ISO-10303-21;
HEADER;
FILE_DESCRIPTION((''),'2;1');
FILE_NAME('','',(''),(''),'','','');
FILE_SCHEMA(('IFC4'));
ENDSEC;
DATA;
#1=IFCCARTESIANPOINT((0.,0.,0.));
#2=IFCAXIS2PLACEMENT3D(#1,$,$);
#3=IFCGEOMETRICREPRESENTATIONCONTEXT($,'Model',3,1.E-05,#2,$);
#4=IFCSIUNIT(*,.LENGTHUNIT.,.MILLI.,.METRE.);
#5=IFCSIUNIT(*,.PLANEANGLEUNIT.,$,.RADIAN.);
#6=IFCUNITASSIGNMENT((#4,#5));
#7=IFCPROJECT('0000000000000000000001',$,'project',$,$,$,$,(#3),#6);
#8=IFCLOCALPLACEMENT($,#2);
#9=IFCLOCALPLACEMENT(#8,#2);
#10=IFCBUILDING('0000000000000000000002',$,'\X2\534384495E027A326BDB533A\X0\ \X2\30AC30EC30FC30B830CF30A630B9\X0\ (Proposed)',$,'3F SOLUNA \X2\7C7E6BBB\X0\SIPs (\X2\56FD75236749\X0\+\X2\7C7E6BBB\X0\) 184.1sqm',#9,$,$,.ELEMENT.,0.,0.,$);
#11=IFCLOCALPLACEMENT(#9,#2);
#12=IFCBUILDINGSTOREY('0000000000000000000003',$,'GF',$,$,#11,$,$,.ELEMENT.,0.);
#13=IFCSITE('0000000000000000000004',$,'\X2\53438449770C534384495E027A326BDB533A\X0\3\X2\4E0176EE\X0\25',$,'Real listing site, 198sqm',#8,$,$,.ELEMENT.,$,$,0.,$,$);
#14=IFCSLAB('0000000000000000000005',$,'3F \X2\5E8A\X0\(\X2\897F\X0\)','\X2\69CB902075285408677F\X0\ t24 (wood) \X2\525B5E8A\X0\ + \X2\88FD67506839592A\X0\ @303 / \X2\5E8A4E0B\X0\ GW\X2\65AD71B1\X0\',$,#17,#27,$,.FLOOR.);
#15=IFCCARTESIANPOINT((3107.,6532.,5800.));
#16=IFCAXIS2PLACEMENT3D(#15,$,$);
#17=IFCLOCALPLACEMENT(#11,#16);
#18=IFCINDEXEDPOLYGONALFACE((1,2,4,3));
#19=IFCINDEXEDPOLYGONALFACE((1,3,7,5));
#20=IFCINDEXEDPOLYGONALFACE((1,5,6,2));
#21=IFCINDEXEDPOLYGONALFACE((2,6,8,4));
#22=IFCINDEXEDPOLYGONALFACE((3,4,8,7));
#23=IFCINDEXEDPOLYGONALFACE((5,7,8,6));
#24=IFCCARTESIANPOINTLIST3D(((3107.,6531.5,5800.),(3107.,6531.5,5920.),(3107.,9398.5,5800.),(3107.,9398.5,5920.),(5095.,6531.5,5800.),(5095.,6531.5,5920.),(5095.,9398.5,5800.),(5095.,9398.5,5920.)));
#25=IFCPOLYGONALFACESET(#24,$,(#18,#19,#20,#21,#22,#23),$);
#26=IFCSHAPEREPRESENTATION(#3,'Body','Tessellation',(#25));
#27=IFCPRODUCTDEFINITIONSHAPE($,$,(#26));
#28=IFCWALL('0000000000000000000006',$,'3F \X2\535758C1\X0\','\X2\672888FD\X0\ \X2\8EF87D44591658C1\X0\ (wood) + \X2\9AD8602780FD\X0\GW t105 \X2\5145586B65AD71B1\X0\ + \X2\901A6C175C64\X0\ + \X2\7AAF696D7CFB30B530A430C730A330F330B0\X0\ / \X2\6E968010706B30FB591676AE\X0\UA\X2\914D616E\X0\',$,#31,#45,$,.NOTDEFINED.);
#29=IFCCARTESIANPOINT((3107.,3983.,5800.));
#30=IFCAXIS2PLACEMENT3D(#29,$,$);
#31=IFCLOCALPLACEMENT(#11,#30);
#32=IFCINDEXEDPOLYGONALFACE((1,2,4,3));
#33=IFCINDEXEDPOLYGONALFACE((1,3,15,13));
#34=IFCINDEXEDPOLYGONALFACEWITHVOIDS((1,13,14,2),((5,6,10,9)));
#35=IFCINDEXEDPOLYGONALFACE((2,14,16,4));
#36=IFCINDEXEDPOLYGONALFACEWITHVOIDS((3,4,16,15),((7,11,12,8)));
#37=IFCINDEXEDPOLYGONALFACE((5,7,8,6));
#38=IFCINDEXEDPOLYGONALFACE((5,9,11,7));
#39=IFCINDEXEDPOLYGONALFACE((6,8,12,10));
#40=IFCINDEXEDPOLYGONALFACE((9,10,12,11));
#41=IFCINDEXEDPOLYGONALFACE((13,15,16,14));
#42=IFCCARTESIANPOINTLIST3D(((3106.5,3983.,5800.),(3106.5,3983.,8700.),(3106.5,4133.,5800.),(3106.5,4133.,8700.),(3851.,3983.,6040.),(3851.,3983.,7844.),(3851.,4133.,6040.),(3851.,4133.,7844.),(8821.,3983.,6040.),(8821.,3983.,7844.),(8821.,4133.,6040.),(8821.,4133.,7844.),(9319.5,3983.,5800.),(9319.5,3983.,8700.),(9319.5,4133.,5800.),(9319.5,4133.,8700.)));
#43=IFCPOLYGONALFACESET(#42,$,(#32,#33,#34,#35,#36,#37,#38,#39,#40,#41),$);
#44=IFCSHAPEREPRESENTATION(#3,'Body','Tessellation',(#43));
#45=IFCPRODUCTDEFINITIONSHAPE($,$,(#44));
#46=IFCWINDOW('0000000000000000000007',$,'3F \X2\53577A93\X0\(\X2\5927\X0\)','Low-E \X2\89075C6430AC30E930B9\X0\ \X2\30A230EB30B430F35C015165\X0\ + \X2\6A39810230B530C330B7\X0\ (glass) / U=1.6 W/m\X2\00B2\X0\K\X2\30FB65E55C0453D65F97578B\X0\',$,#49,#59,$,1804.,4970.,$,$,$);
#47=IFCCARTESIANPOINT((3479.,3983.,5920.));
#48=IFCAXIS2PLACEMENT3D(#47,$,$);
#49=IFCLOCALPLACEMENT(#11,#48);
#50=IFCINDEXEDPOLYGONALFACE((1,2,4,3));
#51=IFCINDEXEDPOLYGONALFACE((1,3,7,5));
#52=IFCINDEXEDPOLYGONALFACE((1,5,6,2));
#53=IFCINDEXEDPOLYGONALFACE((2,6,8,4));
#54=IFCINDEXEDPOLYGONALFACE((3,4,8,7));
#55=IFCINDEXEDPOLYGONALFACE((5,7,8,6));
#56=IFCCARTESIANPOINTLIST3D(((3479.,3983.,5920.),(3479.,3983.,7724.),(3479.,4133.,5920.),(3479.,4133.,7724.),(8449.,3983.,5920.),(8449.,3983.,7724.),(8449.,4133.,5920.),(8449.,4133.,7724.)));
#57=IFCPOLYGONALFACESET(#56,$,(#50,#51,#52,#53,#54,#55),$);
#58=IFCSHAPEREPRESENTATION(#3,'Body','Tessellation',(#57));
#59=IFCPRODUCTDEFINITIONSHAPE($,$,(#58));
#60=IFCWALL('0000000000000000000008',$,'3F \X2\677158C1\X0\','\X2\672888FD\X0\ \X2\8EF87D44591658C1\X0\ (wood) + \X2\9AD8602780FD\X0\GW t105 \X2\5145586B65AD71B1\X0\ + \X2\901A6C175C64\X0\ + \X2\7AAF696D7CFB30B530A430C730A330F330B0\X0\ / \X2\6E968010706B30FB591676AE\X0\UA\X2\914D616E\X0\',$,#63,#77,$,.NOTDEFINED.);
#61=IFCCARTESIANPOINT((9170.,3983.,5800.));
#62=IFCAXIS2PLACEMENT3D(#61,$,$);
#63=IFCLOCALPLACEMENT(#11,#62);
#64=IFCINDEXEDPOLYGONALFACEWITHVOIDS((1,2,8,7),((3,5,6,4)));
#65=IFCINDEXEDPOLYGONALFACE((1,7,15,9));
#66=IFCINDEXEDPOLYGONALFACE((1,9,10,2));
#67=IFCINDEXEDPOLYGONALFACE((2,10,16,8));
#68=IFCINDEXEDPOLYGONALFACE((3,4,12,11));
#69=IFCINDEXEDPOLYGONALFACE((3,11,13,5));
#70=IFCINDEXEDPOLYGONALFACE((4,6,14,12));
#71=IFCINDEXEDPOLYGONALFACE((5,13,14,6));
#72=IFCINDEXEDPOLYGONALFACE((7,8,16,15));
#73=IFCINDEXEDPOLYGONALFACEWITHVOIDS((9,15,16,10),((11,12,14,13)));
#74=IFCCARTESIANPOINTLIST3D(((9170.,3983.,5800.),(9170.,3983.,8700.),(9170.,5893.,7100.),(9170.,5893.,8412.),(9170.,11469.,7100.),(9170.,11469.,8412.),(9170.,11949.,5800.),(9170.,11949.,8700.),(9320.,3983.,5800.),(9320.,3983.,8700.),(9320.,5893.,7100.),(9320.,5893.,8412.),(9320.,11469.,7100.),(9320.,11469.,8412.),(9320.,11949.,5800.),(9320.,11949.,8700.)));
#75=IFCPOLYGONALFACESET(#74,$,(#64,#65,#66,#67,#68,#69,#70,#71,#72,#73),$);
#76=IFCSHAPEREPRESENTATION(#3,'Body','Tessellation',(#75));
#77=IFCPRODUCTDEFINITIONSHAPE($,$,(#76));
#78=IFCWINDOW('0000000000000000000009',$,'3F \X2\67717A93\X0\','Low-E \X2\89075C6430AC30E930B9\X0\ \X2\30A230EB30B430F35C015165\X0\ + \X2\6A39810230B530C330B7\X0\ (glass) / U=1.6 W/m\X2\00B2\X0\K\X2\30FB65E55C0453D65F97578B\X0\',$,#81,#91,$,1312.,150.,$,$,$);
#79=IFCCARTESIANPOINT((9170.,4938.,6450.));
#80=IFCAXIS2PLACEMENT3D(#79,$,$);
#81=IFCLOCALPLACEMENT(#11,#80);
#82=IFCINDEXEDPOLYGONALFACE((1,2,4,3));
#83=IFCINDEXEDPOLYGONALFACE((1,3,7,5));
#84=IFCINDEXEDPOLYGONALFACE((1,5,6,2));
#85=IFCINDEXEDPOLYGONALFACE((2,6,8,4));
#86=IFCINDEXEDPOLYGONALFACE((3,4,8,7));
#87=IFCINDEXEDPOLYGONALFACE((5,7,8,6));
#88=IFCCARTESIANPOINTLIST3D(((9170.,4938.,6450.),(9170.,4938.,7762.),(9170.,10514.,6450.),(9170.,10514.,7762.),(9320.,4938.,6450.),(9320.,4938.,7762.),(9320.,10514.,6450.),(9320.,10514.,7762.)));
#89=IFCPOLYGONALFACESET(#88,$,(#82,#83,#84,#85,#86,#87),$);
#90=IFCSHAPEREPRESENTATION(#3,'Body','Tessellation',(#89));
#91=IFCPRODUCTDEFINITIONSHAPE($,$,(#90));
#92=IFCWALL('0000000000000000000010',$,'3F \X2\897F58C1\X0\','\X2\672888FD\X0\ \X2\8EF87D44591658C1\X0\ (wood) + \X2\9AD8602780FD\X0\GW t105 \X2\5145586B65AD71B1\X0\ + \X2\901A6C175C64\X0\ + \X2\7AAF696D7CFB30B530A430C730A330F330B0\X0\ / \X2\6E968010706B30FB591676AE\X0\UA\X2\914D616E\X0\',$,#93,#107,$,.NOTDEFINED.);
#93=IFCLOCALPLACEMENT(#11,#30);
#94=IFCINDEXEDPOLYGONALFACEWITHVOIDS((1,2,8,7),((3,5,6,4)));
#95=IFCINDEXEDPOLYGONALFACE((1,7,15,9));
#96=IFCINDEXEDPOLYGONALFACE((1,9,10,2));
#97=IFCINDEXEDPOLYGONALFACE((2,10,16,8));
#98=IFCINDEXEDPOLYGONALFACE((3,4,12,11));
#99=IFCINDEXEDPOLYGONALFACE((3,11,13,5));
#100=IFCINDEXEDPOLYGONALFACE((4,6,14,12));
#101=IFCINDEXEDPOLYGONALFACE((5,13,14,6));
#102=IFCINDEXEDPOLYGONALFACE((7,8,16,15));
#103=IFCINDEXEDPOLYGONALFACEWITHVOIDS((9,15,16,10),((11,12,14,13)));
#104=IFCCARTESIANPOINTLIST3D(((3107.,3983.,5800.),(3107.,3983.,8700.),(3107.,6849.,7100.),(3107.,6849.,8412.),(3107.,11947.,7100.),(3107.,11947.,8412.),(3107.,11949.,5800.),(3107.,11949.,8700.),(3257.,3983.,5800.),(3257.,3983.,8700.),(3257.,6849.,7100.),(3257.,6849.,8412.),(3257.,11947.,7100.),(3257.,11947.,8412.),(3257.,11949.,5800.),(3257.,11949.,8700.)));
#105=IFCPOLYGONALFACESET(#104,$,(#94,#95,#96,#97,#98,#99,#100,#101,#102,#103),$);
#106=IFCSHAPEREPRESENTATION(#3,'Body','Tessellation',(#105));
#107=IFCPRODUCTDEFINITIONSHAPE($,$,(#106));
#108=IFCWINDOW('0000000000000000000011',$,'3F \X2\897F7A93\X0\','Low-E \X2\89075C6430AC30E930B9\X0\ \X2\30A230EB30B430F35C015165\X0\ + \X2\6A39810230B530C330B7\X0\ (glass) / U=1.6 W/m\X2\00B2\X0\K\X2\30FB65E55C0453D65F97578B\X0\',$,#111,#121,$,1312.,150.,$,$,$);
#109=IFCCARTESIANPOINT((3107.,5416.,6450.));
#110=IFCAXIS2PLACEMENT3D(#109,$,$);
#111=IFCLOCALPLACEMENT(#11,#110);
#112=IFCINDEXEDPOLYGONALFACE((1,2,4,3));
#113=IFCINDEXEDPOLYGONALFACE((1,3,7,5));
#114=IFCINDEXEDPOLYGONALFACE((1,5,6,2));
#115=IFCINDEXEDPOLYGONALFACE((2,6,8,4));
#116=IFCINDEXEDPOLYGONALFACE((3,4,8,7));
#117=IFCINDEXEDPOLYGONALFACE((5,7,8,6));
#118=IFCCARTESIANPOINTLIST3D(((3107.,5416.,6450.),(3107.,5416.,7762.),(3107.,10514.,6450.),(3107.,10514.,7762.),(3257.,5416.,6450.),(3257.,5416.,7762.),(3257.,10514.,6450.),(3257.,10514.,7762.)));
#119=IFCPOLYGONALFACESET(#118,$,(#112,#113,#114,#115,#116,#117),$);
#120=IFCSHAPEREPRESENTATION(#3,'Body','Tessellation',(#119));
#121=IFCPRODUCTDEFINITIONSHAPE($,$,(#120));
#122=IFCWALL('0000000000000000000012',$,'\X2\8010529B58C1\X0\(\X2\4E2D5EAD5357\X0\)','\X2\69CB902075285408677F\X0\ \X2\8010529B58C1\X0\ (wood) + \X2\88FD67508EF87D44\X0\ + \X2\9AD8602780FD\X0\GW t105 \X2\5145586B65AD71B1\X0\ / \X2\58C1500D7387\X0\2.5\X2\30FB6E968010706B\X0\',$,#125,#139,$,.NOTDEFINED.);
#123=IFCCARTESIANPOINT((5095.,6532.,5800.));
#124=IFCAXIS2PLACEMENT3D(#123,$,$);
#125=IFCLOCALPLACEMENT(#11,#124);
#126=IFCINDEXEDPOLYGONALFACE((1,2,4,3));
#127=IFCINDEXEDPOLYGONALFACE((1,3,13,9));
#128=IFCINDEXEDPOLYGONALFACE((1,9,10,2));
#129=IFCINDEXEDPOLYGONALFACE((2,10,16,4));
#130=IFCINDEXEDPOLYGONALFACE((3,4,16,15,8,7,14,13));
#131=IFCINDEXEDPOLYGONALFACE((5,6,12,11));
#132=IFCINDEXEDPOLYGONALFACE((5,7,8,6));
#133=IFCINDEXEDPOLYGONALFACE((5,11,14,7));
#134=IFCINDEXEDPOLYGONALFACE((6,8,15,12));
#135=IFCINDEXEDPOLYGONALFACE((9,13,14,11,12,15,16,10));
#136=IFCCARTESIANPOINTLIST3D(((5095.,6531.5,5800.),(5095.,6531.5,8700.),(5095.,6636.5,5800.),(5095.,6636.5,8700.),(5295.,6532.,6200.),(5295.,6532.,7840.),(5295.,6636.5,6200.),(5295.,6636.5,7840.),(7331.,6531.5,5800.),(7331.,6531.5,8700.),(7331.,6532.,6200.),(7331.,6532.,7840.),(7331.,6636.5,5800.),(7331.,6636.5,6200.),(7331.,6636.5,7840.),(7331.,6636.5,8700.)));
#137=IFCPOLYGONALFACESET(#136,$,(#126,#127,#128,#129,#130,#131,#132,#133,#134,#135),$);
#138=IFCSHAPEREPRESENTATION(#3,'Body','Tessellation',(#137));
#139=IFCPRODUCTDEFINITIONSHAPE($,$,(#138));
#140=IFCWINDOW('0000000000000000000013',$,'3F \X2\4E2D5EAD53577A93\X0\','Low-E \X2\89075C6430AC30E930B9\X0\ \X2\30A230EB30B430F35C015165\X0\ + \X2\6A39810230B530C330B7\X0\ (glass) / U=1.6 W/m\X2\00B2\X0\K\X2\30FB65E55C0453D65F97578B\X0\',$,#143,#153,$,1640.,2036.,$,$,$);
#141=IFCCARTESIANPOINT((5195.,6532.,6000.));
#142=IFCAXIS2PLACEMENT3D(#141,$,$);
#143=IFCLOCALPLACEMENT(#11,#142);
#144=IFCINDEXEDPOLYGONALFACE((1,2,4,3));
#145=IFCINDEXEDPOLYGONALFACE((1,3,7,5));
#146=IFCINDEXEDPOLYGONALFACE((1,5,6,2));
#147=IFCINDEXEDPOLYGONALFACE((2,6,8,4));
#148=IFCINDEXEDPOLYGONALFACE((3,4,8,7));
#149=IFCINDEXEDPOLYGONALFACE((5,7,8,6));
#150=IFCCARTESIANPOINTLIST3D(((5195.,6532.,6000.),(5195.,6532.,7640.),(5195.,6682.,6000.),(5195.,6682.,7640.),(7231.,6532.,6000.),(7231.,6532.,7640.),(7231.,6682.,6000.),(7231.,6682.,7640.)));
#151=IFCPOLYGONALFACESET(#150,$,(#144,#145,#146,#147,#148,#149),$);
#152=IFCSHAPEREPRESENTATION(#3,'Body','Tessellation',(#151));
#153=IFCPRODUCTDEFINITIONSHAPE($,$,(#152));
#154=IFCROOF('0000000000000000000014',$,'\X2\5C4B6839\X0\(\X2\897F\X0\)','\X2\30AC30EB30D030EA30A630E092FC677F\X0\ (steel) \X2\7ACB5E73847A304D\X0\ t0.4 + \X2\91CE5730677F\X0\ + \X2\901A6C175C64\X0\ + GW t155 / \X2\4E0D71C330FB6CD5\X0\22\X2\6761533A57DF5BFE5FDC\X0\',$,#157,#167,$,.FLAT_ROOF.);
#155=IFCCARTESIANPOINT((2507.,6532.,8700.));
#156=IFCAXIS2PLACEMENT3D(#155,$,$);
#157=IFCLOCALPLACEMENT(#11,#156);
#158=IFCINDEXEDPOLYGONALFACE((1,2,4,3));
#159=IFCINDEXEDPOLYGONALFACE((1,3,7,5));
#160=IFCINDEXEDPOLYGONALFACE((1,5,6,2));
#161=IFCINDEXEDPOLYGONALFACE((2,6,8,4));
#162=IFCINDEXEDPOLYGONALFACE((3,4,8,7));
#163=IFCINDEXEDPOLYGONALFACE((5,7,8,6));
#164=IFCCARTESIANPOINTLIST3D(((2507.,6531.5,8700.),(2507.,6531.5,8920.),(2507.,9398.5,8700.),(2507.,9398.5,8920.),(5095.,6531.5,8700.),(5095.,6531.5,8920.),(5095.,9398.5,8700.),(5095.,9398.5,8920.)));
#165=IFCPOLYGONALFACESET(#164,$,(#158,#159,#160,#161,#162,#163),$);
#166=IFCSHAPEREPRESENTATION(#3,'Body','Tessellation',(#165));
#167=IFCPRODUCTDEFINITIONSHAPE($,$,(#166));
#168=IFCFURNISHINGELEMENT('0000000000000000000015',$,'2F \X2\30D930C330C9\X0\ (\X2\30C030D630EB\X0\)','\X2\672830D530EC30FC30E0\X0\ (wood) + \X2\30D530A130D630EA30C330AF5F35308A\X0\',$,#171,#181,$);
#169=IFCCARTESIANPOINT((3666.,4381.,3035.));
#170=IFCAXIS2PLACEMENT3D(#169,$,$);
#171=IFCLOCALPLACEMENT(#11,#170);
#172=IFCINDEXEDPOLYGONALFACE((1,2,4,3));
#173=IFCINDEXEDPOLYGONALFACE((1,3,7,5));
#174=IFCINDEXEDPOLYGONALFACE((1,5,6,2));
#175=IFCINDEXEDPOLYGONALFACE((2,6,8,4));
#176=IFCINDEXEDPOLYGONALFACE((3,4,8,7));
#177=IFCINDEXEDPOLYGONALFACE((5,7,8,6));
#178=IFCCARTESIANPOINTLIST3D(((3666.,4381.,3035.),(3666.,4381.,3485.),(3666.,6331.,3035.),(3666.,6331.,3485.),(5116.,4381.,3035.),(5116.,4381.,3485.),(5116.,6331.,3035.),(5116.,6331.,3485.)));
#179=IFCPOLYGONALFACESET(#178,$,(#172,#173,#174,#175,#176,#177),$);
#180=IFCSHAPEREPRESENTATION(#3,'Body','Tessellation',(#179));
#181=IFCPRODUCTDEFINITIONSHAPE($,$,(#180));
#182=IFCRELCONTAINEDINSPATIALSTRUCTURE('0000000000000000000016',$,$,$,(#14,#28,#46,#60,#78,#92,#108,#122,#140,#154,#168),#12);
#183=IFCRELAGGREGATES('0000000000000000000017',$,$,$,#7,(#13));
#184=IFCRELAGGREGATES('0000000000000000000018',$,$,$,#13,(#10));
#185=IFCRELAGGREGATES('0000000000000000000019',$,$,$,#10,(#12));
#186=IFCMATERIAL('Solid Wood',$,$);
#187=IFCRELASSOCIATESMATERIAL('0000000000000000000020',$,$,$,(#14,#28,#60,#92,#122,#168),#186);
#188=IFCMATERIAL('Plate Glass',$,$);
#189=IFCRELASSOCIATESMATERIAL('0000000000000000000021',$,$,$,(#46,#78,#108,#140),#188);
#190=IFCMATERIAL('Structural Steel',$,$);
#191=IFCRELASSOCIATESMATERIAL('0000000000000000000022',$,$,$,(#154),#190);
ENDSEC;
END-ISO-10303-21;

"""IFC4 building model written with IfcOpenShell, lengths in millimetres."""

from ifc_helpers import new_model, si_unit, frame, frame_2d, origin, place, context, project, spatial, rectangle, extrude, material, element, fill, save


model = new_model("IFC4")

# Units and contexts
model_context = context("Model", 3, precision=1e-05, world=origin())
ifc_project = project(units=[si_unit("LENGTHUNIT", "METRE", prefix="MILLI"), si_unit("PLANEANGLEUNIT", "RADIAN")], contexts=[model_context])

# Site, building, storey
site_placement = place(None, origin())
site = spatial("IfcSite", under=ifc_project, at=site_placement, Name="千葉県千葉市稲毛区3丁目25", ObjectType="Real listing site, 198sqm", CompositionType="ELEMENT", RefElevation=0.0)
building_placement = place(site_placement, origin())
building = spatial("IfcBuilding", under=site, at=building_placement, Name="千葉市稲毛区 ガレージハウス (Proposed)", ObjectType="3F SOLUNA 籾殻SIPs (国産杉+籾殻) 184.1sqm", CompositionType="ELEMENT", ElevationOfRefHeight=0.0, ElevationOfTerrain=0.0)
storey_placement = place(building_placement, origin())
storey = spatial("IfcBuildingStorey", under=building, at=storey_placement, Name="GF", CompositionType="ELEMENT", Elevation=0.0)

# Slab
ifc_material_1 = material(Name="Solid Wood")
slab_1_placement = place(storey_placement, frame((3107.0, 6532.0, 5800.0)))
element("IfcSlab", 1, at=slab_1_placement, inside=storey, material=ifc_material_1, Name="3F 床(西)", Description="構造用合板 t24 (wood) 剛床 + 製材根太 @303 / 床下 GW断熱", PredefinedType="FLOOR", context=model_context, shape_type="SweptSolid", body=[
    extrude(rectangle(XDim=1988.0, YDim=2867.0, at=frame_2d((994.0, 1433.0))), frame((3107.0, 6532.0, 5800.0)), (0.0, 0.0, 1.0), 120.0),
])

# Walls, openings, windows
wall_1_placement = place(storey_placement, frame((3107.0, 3983.0, 5800.0)))
wall_1 = element("IfcWall", 2, at=wall_1_placement, inside=storey, material=ifc_material_1, Name="3F 南壁", Description="木製 軸組外壁 (wood) + 高性能GW t105 充填断熱 + 通気層 + 窯業系サイディング / 準耐火・外皮UA配慮", PredefinedType="NOTDEFINED", context=model_context, shape_type="SweptSolid", body=[
    extrude(rectangle(XDim=6213.0, YDim=150.0, at=frame_2d((3106.0, 75.0))), frame((3107.0, 3983.0, 5800.0)), (0.0, 0.0, 1.0), 2900.0),
])
opening_1_placement = place(storey_placement, frame((3479.0, 3983.0, 5920.0)))
opening_1 = element("IfcOpeningElement", 3, at=opening_1_placement, cuts=wall_1, PredefinedType="NOTDEFINED", context=model_context, shape_type="SweptSolid", body=[
    extrude(rectangle(XDim=4970.0, YDim=150.0, at=frame_2d((2485.0, 75.0))), frame((3479.0, 3983.0, 5920.0)), (0.0, 0.0, 1.0), 1804.0),
])
ifc_material_2 = material(Name="Plate Glass")
window_1_placement = place(storey_placement, frame((3479.0, 3983.0, 5920.0)))
window_1 = element("IfcWindow", 4, at=window_1_placement, inside=storey, material=ifc_material_2, Name="3F 南窓(大)", Description="Low-E 複層ガラス アルゴン封入 + 樹脂サッシ (glass) / U=1.6 W/m²K・日射取得型", OverallHeight=1804.0, OverallWidth=4970.0, context=model_context, shape_type="SweptSolid", body=[
    extrude(rectangle(XDim=4970.0, YDim=150.0, at=frame_2d((2485.0, 75.0))), frame((3479.0, 3983.0, 5920.0)), (0.0, 0.0, 1.0), 1804.0),
])
fill(opening_1, window_1)
wall_2_placement = place(storey_placement, frame((9170.0, 3983.0, 5800.0)))
wall_2 = element("IfcWall", 5, at=wall_2_placement, inside=storey, material=ifc_material_1, Name="3F 東壁", Description="木製 軸組外壁 (wood) + 高性能GW t105 充填断熱 + 通気層 + 窯業系サイディング / 準耐火・外皮UA配慮", PredefinedType="NOTDEFINED", context=model_context, shape_type="SweptSolid", body=[
    extrude(rectangle(XDim=150.0, YDim=7966.0, at=frame_2d((75.0, 3983.0))), frame((9170.0, 3983.0, 5800.0)), (0.0, 0.0, 1.0), 2900.0),
])
opening_2_placement = place(storey_placement, frame((9170.0, 4938.0, 6450.0)))
opening_2 = element("IfcOpeningElement", 6, at=opening_2_placement, cuts=wall_2, PredefinedType="NOTDEFINED", context=model_context, shape_type="SweptSolid", body=[
    extrude(rectangle(XDim=150.0, YDim=5576.0, at=frame_2d((75.0, 2788.0))), frame((9170.0, 4938.0, 6450.0)), (0.0, 0.0, 1.0), 1312.0),
])
window_2_placement = place(storey_placement, frame((9170.0, 4938.0, 6450.0)))
window_2 = element("IfcWindow", 7, at=window_2_placement, inside=storey, material=ifc_material_2, Name="3F 東窓", Description="Low-E 複層ガラス アルゴン封入 + 樹脂サッシ (glass) / U=1.6 W/m²K・日射取得型", OverallHeight=1312.0, OverallWidth=150.0, context=model_context, shape_type="SweptSolid", body=[
    extrude(rectangle(XDim=150.0, YDim=5576.0, at=frame_2d((75.0, 2788.0))), frame((9170.0, 4938.0, 6450.0)), (0.0, 0.0, 1.0), 1312.0),
])
fill(opening_2, window_2)
wall_3_placement = place(storey_placement, frame((3107.0, 3983.0, 5800.0)))
wall_3 = element("IfcWall", 8, at=wall_3_placement, inside=storey, material=ifc_material_1, Name="3F 西壁", Description="木製 軸組外壁 (wood) + 高性能GW t105 充填断熱 + 通気層 + 窯業系サイディング / 準耐火・外皮UA配慮", PredefinedType="NOTDEFINED", context=model_context, shape_type="SweptSolid", body=[
    extrude(rectangle(XDim=150.0, YDim=7966.0, at=frame_2d((75.0, 3983.0))), frame((3107.0, 3983.0, 5800.0)), (0.0, 0.0, 1.0), 2900.0),
])
opening_3_placement = place(storey_placement, frame((3107.0, 5416.0, 6450.0)))
opening_3 = element("IfcOpeningElement", 9, at=opening_3_placement, cuts=wall_3, PredefinedType="NOTDEFINED", context=model_context, shape_type="SweptSolid", body=[
    extrude(rectangle(XDim=150.0, YDim=5098.0, at=frame_2d((75.0, 2549.0))), frame((3107.0, 5416.0, 6450.0)), (0.0, 0.0, 1.0), 1312.0),
])
window_3_placement = place(storey_placement, frame((3107.0, 5416.0, 6450.0)))
window_3 = element("IfcWindow", 10, at=window_3_placement, inside=storey, material=ifc_material_2, Name="3F 西窓", Description="Low-E 複層ガラス アルゴン封入 + 樹脂サッシ (glass) / U=1.6 W/m²K・日射取得型", OverallHeight=1312.0, OverallWidth=150.0, context=model_context, shape_type="SweptSolid", body=[
    extrude(rectangle(XDim=150.0, YDim=5098.0, at=frame_2d((75.0, 2549.0))), frame((3107.0, 5416.0, 6450.0)), (0.0, 0.0, 1.0), 1312.0),
])
fill(opening_3, window_3)
wall_4_placement = place(storey_placement, frame((5095.0, 6532.0, 5800.0)))
wall_4 = element("IfcWall", 11, at=wall_4_placement, inside=storey, material=ifc_material_1, Name="耐力壁(中庭南)", Description="構造用合板 耐力壁 (wood) + 製材軸組 + 高性能GW t105 充填断熱 / 壁倍率2.5・準耐火", PredefinedType="NOTDEFINED", context=model_context, shape_type="SweptSolid", body=[
    extrude(rectangle(XDim=2236.0, YDim=105.0, at=frame_2d((1118.0, 52.0))), frame((5095.0, 6532.0, 5800.0)), (0.0, 0.0, 1.0), 2900.0),
])
opening_4_placement = place(storey_placement, frame((5195.0, 6532.0, 6000.0)))
opening_4 = element("IfcOpeningElement", 12, at=opening_4_placement, cuts=wall_4, PredefinedType="NOTDEFINED", context=model_context, shape_type="SweptSolid", body=[
    extrude(rectangle(XDim=2036.0, YDim=150.0, at=frame_2d((1018.0, 75.0))), frame((5195.0, 6532.0, 6000.0)), (0.0, 0.0, 1.0), 1640.0),
])
window_4_placement = place(storey_placement, frame((5195.0, 6532.0, 6000.0)))
window_4 = element("IfcWindow", 13, at=window_4_placement, inside=storey, material=ifc_material_2, Name="3F 中庭南窓", Description="Low-E 複層ガラス アルゴン封入 + 樹脂サッシ (glass) / U=1.6 W/m²K・日射取得型", OverallHeight=1640.0, OverallWidth=2036.0, context=model_context, shape_type="SweptSolid", body=[
    extrude(rectangle(XDim=2036.0, YDim=150.0, at=frame_2d((1018.0, 75.0))), frame((5195.0, 6532.0, 6000.0)), (0.0, 0.0, 1.0), 1640.0),
])
fill(opening_4, window_4)

# Roof
ifc_material_3 = material(Name="Structural Steel")
roof_1_placement = place(storey_placement, frame((2507.0, 6532.0, 8700.0)))
element("IfcRoof", 14, at=roof_1_placement, inside=storey, material=ifc_material_3, Name="屋根(西)", Description="ガルバリウム鋼板 (steel) 立平葺き t0.4 + 野地板 + 通気層 + GW t155 / 不燃・法22条区域対応", PredefinedType="FLAT_ROOF", context=model_context, shape_type="SweptSolid", body=[
    extrude(rectangle(XDim=2588.0, YDim=2867.0, at=frame_2d((1294.0, 1433.0))), frame((2507.0, 6532.0, 8700.0)), (0.0, 0.0, 1.0), 220.0),
])

# Furnishing element
furnishing_1_placement = place(storey_placement, frame((3666.0, 4381.0, 3035.0)))
element("IfcFurnishingElement", 15, at=furnishing_1_placement, inside=storey, material=ifc_material_1, Name="2F ベッド (ダブル)", Description="木フレーム (wood) + ファブリック張り", context=model_context, shape_type="SweptSolid", body=[
    extrude(rectangle(XDim=1450.0, YDim=1950.0, at=frame_2d((725.0, 975.0))), frame((3666.0, 4381.0, 3035.0)), (0.0, 0.0, 1.0), 450.0),
])

save(model, "model.ifc")
